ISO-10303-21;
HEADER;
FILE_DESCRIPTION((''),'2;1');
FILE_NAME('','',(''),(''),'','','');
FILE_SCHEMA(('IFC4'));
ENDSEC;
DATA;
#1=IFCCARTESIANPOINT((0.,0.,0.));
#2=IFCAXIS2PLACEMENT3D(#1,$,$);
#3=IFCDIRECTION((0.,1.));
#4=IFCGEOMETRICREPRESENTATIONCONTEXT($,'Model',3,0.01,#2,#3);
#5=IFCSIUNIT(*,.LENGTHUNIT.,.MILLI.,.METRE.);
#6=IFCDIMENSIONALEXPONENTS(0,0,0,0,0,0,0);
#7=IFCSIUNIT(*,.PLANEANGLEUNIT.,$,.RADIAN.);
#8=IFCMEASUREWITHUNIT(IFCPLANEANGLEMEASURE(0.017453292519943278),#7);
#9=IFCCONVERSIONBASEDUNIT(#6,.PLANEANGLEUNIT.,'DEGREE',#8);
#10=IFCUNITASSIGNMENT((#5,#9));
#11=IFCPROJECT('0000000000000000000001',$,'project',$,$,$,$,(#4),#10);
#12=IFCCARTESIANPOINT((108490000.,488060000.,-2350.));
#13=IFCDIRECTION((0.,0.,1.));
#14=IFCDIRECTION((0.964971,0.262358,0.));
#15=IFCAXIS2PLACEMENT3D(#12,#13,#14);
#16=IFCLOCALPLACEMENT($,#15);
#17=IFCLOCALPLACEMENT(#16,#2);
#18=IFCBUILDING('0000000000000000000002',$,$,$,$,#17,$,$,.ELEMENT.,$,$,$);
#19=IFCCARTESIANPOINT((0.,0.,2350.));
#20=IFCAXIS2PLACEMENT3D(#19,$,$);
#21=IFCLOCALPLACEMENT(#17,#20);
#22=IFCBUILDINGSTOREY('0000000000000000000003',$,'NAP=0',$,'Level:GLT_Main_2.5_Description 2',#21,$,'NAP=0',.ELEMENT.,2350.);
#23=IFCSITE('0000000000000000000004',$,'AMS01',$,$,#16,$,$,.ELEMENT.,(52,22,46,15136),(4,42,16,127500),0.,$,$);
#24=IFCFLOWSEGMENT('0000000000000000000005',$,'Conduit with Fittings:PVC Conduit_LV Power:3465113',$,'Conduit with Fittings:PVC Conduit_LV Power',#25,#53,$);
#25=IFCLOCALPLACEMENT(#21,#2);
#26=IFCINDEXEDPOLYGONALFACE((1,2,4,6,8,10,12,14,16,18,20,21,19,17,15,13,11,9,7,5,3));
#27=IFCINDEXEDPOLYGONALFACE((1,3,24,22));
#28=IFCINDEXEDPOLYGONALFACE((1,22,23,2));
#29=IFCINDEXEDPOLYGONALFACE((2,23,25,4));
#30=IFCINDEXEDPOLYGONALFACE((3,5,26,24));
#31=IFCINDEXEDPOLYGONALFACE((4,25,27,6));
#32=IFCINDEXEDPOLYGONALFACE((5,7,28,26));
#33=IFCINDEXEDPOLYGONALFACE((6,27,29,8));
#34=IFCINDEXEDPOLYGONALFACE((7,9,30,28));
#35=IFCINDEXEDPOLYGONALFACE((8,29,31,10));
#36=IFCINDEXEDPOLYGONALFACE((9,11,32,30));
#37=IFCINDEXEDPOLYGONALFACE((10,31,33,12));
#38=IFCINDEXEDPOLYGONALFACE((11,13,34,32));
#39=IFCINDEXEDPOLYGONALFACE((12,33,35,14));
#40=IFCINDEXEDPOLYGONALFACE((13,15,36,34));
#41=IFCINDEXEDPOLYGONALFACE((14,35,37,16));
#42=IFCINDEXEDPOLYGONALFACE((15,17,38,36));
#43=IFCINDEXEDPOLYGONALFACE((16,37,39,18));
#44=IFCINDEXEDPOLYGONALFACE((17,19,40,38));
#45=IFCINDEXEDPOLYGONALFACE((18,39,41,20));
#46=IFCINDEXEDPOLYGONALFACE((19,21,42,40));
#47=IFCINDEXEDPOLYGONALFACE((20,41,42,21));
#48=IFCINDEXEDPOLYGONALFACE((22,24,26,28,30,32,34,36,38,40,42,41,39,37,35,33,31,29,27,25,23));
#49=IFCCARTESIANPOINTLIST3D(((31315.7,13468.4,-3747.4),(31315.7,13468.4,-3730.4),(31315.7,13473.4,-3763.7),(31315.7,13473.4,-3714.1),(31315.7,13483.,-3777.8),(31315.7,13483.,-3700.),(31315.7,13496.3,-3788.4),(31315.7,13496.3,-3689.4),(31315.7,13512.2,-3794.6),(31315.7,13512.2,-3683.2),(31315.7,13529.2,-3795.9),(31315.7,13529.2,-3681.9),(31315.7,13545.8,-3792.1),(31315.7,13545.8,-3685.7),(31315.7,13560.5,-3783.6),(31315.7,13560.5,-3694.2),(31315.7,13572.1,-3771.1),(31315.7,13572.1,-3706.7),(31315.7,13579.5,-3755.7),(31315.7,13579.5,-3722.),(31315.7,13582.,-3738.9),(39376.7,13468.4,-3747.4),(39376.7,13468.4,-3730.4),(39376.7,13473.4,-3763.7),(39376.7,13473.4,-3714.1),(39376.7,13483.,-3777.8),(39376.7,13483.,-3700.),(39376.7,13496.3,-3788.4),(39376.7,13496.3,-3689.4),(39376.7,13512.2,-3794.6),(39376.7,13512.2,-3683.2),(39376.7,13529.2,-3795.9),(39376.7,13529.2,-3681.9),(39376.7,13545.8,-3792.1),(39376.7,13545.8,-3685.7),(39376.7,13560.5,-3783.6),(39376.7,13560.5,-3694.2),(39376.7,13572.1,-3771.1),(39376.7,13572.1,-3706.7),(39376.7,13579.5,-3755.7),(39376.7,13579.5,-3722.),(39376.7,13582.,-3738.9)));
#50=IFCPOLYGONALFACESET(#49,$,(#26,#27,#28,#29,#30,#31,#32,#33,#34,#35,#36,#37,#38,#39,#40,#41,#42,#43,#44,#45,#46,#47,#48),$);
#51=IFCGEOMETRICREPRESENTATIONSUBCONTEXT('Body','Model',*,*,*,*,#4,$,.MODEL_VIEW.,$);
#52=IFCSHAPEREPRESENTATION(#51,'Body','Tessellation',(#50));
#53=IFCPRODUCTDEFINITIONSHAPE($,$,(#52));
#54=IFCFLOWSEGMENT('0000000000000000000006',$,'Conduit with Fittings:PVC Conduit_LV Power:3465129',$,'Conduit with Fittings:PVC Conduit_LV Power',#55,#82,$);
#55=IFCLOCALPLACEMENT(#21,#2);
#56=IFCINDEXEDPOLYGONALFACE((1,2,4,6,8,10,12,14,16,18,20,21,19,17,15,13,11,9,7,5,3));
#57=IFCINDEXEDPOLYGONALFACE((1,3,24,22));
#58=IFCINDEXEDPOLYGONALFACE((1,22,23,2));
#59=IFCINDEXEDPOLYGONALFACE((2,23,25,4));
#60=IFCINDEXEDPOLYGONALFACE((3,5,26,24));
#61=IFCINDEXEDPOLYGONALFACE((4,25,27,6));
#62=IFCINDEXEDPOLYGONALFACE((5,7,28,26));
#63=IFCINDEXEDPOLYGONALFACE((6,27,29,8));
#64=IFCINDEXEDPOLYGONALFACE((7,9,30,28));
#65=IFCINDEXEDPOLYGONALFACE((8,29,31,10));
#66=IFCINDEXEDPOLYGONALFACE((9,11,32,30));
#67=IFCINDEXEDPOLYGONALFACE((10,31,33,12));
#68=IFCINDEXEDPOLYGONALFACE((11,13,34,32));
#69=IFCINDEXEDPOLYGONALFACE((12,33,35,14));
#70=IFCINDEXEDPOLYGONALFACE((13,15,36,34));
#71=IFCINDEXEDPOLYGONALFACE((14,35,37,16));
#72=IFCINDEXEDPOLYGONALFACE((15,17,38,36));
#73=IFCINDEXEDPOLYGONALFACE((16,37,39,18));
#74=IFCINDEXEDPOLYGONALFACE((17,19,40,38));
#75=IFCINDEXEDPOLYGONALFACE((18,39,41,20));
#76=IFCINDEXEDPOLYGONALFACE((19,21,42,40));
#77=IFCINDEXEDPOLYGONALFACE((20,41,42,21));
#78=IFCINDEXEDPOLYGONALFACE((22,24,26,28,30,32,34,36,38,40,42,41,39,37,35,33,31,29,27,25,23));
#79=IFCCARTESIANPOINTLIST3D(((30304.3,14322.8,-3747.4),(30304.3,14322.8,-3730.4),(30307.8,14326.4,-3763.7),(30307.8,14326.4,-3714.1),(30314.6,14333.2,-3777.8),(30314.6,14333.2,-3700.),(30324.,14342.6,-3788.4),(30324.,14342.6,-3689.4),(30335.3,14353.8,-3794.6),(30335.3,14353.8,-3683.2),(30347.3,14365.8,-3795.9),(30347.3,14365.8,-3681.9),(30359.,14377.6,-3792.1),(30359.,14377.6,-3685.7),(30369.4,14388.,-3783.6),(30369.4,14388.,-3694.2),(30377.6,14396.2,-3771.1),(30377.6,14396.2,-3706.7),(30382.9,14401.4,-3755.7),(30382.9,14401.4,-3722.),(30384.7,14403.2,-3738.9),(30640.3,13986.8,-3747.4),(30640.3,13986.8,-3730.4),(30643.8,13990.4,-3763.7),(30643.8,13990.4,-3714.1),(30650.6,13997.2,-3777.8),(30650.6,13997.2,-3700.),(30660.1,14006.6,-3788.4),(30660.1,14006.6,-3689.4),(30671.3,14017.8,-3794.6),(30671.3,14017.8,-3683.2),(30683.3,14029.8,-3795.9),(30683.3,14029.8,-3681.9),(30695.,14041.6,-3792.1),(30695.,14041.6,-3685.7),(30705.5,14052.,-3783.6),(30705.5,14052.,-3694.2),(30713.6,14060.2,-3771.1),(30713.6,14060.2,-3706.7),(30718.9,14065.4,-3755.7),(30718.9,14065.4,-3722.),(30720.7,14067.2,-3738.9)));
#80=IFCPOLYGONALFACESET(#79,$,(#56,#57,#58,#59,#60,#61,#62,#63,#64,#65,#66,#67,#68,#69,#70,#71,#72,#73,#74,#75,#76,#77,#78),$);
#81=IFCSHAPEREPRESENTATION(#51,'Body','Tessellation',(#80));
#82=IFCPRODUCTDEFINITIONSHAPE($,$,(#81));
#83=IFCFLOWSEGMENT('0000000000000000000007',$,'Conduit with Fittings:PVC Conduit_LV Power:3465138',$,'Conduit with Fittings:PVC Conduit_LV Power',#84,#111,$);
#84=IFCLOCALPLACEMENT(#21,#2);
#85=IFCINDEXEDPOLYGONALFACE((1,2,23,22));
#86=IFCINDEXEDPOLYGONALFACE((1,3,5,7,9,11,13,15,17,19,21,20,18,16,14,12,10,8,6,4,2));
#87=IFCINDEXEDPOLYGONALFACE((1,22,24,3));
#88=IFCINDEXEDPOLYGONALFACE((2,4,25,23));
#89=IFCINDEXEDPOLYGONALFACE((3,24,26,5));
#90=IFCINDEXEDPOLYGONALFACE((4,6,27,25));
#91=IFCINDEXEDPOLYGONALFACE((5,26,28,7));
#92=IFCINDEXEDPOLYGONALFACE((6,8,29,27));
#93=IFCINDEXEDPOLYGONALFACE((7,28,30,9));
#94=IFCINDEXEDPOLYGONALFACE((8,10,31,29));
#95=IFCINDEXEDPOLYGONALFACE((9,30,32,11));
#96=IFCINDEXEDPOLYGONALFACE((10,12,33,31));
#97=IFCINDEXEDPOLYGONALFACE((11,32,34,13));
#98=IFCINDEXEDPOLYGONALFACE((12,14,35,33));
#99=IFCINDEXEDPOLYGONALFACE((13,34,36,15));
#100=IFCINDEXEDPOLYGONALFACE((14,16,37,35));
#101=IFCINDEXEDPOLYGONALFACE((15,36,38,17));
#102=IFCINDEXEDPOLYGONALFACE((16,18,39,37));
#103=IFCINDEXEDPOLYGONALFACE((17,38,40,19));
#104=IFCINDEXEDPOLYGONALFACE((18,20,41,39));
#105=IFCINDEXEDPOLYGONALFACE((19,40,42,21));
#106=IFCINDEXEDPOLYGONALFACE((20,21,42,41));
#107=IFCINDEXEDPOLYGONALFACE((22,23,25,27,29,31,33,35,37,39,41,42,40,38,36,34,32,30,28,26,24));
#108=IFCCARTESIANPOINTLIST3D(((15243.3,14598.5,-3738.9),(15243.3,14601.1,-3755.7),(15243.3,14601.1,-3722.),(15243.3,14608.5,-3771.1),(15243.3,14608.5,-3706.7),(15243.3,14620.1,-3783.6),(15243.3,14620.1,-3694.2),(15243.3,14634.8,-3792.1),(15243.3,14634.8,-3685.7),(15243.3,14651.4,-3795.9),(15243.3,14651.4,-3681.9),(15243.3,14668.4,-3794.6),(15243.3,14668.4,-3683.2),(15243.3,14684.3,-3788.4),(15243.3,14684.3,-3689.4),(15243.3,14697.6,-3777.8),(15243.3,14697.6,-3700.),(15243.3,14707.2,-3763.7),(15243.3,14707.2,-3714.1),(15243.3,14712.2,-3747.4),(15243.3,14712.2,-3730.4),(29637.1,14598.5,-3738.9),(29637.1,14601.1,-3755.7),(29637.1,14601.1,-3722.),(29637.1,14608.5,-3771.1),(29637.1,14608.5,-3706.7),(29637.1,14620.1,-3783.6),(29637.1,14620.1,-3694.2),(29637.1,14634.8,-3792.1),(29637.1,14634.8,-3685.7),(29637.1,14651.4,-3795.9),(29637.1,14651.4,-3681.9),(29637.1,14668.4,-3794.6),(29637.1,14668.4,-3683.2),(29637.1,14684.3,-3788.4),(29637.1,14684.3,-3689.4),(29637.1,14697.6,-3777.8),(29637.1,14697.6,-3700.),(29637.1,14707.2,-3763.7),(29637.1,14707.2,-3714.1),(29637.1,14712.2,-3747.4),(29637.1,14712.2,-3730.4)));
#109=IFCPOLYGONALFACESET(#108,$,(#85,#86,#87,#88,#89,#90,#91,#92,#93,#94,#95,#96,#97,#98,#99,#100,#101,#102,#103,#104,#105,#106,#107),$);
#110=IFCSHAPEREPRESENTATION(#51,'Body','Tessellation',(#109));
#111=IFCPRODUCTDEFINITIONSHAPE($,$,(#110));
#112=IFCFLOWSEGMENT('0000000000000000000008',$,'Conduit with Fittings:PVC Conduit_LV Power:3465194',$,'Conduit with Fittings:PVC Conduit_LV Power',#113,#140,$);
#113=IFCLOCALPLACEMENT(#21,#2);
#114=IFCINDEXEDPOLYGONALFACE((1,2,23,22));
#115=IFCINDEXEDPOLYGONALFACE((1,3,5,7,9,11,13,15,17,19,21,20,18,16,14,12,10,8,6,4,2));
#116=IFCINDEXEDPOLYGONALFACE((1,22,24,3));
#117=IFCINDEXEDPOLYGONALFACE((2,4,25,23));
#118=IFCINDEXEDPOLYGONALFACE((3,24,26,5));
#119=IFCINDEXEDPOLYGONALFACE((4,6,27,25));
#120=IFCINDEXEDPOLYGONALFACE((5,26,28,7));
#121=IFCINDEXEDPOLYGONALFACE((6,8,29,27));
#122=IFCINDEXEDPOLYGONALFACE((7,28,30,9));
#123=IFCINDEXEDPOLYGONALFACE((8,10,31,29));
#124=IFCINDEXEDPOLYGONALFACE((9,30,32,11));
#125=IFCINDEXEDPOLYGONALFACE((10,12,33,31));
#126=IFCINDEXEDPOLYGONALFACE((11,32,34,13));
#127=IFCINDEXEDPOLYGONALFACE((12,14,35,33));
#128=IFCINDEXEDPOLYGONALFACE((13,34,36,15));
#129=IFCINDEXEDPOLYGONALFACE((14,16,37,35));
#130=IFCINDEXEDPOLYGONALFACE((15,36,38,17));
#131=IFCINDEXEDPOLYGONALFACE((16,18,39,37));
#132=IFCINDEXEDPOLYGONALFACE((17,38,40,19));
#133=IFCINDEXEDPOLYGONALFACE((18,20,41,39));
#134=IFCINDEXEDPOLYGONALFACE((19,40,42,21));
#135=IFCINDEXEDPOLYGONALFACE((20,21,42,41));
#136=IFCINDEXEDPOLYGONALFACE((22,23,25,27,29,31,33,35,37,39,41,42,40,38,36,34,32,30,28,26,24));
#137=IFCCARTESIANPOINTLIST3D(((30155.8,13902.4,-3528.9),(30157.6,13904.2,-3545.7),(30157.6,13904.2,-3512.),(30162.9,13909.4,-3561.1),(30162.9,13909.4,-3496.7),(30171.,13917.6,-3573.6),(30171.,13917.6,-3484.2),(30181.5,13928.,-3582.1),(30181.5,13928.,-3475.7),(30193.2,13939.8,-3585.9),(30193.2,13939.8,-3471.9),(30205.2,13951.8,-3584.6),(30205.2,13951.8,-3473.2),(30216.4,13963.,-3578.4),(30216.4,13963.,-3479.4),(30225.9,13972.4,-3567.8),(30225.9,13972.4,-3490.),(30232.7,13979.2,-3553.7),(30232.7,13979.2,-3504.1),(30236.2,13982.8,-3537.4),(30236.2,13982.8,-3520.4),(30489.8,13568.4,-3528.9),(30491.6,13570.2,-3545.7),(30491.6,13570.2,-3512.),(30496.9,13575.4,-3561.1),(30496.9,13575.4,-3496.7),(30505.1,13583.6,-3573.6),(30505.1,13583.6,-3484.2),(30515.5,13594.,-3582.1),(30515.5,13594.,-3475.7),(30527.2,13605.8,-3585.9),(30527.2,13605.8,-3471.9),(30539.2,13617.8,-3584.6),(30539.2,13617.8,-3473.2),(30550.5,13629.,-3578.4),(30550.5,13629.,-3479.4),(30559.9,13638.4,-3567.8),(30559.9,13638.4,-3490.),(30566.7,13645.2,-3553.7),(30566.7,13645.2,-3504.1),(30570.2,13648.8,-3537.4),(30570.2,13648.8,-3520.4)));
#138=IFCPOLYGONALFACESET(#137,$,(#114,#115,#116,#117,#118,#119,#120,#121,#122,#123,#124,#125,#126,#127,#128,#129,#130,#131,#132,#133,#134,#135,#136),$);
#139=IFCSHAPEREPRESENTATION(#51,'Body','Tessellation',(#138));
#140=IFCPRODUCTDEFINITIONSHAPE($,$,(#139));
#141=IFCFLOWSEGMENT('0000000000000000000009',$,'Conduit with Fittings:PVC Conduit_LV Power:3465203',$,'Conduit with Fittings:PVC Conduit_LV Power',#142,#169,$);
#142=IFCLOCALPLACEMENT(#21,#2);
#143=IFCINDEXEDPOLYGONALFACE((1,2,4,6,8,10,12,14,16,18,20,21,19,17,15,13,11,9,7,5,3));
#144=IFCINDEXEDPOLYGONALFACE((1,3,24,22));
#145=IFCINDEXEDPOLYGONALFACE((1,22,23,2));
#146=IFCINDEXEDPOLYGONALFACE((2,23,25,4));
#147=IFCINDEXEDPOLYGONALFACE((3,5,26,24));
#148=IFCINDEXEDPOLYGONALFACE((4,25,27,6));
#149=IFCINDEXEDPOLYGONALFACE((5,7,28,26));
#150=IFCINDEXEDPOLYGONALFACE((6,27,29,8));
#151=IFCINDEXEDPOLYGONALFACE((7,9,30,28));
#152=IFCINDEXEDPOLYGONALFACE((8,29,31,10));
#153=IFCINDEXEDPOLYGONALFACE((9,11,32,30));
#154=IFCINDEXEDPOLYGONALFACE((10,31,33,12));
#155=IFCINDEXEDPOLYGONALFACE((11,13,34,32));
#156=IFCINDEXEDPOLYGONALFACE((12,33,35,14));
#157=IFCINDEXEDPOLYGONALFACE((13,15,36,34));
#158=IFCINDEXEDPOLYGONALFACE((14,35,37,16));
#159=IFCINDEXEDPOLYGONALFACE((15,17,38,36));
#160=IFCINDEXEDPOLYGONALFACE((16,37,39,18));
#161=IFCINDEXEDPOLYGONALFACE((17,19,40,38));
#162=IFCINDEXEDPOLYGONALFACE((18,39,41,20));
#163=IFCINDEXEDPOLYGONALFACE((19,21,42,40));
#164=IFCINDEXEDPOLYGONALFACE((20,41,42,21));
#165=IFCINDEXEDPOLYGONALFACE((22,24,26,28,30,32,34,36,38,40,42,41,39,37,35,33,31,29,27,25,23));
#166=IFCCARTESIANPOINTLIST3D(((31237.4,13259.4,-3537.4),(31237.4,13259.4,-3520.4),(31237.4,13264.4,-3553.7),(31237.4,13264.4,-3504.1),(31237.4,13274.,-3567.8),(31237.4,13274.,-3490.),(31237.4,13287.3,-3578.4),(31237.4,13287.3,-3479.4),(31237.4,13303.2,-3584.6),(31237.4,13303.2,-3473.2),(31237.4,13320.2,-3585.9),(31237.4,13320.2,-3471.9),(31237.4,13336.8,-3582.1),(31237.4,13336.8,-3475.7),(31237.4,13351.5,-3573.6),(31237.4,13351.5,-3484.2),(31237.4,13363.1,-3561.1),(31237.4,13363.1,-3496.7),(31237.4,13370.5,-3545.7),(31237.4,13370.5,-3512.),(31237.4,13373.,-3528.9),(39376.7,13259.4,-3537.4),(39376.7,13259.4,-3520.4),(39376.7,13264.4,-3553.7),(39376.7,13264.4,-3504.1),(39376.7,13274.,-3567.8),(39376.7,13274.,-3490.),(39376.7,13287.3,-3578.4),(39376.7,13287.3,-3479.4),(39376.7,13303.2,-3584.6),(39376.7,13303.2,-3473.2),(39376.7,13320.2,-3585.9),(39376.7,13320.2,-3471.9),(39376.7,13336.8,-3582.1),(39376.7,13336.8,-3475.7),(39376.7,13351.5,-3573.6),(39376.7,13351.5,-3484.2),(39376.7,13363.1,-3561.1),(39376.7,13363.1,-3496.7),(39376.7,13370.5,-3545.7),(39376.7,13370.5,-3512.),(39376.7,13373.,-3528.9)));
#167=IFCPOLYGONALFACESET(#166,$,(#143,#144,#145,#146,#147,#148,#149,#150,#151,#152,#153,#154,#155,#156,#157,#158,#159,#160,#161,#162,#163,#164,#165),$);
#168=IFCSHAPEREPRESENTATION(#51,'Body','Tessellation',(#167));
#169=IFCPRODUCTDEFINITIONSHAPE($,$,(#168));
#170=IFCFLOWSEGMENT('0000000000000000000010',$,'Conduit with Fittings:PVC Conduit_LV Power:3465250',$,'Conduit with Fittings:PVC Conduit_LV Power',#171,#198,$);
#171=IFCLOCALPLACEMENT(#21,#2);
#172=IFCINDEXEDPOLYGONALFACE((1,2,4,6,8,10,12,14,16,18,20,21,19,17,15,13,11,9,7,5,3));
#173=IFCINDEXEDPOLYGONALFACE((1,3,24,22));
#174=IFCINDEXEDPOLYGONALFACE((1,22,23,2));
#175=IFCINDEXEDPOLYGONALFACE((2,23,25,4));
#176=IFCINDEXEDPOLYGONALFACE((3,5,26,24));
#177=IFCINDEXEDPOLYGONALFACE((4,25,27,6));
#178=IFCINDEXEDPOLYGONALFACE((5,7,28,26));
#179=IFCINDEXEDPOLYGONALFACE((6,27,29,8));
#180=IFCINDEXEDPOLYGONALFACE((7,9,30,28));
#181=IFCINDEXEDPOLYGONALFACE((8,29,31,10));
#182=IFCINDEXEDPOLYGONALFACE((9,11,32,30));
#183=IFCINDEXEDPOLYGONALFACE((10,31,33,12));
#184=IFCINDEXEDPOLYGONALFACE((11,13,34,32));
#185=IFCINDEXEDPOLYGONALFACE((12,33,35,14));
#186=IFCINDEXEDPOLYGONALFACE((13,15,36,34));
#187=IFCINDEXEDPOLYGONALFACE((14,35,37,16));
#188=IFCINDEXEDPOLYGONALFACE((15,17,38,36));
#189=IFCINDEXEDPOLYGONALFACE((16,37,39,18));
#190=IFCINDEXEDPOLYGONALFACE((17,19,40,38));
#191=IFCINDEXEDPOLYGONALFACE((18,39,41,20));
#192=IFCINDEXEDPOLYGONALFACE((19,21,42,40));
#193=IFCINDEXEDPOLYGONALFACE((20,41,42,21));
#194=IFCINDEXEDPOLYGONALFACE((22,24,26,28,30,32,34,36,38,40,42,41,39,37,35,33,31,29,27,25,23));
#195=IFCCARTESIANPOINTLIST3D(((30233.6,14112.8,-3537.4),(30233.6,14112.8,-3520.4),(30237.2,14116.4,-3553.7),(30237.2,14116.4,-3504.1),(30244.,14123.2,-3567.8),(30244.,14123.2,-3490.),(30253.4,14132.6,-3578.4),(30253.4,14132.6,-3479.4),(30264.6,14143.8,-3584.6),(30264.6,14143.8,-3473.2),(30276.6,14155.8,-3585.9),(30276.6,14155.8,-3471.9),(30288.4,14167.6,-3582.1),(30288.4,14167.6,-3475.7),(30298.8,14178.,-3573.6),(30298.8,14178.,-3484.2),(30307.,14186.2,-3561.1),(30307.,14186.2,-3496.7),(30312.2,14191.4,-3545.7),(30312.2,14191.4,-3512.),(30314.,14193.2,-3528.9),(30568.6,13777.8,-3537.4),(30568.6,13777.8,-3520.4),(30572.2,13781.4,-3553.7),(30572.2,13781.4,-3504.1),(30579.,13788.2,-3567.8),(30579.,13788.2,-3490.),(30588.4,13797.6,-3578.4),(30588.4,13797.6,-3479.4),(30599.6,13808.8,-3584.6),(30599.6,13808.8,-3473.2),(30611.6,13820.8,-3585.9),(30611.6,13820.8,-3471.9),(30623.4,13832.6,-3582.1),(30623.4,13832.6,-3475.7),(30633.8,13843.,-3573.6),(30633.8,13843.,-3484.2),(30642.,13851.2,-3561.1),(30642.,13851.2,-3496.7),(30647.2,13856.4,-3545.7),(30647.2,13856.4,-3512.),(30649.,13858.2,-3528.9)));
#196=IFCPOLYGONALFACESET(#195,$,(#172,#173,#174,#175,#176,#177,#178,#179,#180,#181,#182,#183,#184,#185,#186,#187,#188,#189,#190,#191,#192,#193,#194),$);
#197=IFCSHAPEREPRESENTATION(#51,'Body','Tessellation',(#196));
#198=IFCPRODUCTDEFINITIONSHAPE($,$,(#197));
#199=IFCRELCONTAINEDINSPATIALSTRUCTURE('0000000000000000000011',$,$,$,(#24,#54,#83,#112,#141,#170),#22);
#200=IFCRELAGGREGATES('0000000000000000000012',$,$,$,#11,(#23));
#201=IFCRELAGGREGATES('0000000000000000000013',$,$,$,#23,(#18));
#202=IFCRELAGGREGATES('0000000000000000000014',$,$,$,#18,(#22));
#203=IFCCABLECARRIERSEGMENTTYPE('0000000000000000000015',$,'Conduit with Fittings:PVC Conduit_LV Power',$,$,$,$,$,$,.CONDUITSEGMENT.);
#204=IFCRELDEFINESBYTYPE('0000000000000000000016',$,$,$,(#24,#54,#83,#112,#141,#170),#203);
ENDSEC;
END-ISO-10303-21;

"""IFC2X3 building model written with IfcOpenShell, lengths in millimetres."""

from ifc_helpers import new_model, entity, si_unit, converted_unit, direction, frame, frame_2d, origin, origin_2d_with_axis, place, context, subcontext, project, spatial, circle, extrude, type_object, element, save


model = new_model("IFC2X3")

# Units and contexts
model_context = context("Model", 3, precision=0.01, world=origin(), true_north=direction((0.0, 1.0)))
body_context = subcontext(model_context, "Body", "Model", "MODEL_VIEW")
ifc_project = project(units=[si_unit("LENGTHUNIT", "METRE", prefix="MILLI"), converted_unit("PLANEANGLEUNIT", "DEGREE", entity("IfcPlaneAngleMeasure", 0.017453292519943278), si_unit("PLANEANGLEUNIT", "RADIAN"), dimensions=[0, 0, 0, 0, 0, 0, 0])], contexts=[model_context])

# Site, building, storey
site_placement = place(None, frame((108490000.0, 488060000.0, -2350.0), z_axis=(0.0, 0.0, 1.0), x_axis=(0.964971, 0.262358, 0.0)))
site = spatial("IfcSite", under=ifc_project, at=site_placement, Name="AMS01", CompositionType="ELEMENT", RefLatitude=(52, 22, 46, 15136), RefLongitude=(4, 42, 16, 127500), RefElevation=0.0)
building_placement = place(site_placement, origin())
building = spatial("IfcBuilding", under=site, at=building_placement, CompositionType="ELEMENT")
storey_placement = place(building_placement, frame((0.0, 0.0, 2350.0)))
storey = spatial("IfcBuildingStorey", under=building, at=storey_placement, Name="NAP=0", ObjectType="Level:GLT_Main_2.5_Description 2", LongName="NAP=0", CompositionType="ELEMENT", Elevation=2350.0)

# Flow segments
cable_carrier_segment_type = type_object("IfcCableCarrierSegmentType", Name="Conduit with Fittings:PVC Conduit_LV Power", PredefinedType="CONDUITSEGMENT")
flow_segment_1_placement = place(storey_placement, origin())
element("IfcFlowSegment", 1, at=flow_segment_1_placement, inside=storey, type_object=cable_carrier_segment_type, Name="Conduit with Fittings:PVC Conduit_LV Power:3465113", ObjectType="Conduit with Fittings:PVC Conduit_LV Power", context=body_context, shape_type="SweptSolid", body=[
    extrude(circle(Radius=57.2, at=frame_2d((0.0, 0.0), x_axis=(1.0, 0.0))), frame((31315.7, 13524.9, -3738.9), z_axis=(1.0, 0.0, 0.0), x_axis=(0.0, 1.0, 0.0)), (0.0, 0.0, 1.0), 8061.0),
])
flow_segment_2_placement = place(storey_placement, origin())
element("IfcFlowSegment", 2, at=flow_segment_2_placement, inside=storey, type_object=cable_carrier_segment_type, Name="Conduit with Fittings:PVC Conduit_LV Power:3465129", ObjectType="Conduit with Fittings:PVC Conduit_LV Power", context=body_context, shape_type="SweptSolid", body=[
    extrude(circle(Radius=57.2, at=origin_2d_with_axis()), frame((30344.2, 14362.8, -3738.9), z_axis=(0.707107, -0.707107, 0.0), x_axis=(0.707107, 0.707107, 0.0)), (0.0, 0.0, 1.0), 475.2),
])
flow_segment_3_placement = place(storey_placement, origin())
element("IfcFlowSegment", 3, at=flow_segment_3_placement, inside=storey, type_object=cable_carrier_segment_type, Name="Conduit with Fittings:PVC Conduit_LV Power:3465138", ObjectType="Conduit with Fittings:PVC Conduit_LV Power", context=body_context, shape_type="SweptSolid", body=[
    extrude(circle(Radius=57.2, at=origin_2d_with_axis()), frame((15243.3, 14655.7, -3738.9), z_axis=(1.0, 0.0, 0.0), x_axis=(0.0, -1.0, 0.0)), (0.0, 0.0, 1.0), 14393.8),
])
flow_segment_4_placement = place(storey_placement, origin())
element("IfcFlowSegment", 4, at=flow_segment_4_placement, inside=storey, type_object=cable_carrier_segment_type, Name="Conduit with Fittings:PVC Conduit_LV Power:3465194", ObjectType="Conduit with Fittings:PVC Conduit_LV Power", context=body_context, shape_type="SweptSolid", body=[
    extrude(circle(Radius=57.2, at=origin_2d_with_axis()), frame((30196.2, 13942.8, -3528.9), z_axis=(0.707107, -0.707107, 0.0), x_axis=(-0.707107, -0.707107, 0.0)), (0.0, 0.0, 1.0), 472.4),
])
flow_segment_5_placement = place(storey_placement, origin())
element("IfcFlowSegment", 5, at=flow_segment_5_placement, inside=storey, type_object=cable_carrier_segment_type, Name="Conduit with Fittings:PVC Conduit_LV Power:3465203", ObjectType="Conduit with Fittings:PVC Conduit_LV Power", context=body_context, shape_type="SweptSolid", body=[
    extrude(circle(Radius=57.2, at=frame_2d((0.0, 0.0), x_axis=(1.0, 0.0))), frame((31237.4, 13315.9, -3528.9), z_axis=(1.0, 0.0, 0.0), x_axis=(0.0, 1.0, 0.0)), (0.0, 0.0, 1.0), 8139.3),
])
flow_segment_6_placement = place(storey_placement, origin())
element("IfcFlowSegment", 6, at=flow_segment_6_placement, inside=storey, type_object=cable_carrier_segment_type, Name="Conduit with Fittings:PVC Conduit_LV Power:3465250", ObjectType="Conduit with Fittings:PVC Conduit_LV Power", context=body_context, shape_type="SweptSolid", body=[
    extrude(circle(Radius=57.2, at=origin_2d_with_axis()), frame((30273.6, 14152.8, -3528.9), z_axis=(0.707107, -0.707107, 0.0), x_axis=(0.707107, 0.707107, 0.0)), (0.0, 0.0, 1.0), 473.8),
])

save(model, "model.ifc")
